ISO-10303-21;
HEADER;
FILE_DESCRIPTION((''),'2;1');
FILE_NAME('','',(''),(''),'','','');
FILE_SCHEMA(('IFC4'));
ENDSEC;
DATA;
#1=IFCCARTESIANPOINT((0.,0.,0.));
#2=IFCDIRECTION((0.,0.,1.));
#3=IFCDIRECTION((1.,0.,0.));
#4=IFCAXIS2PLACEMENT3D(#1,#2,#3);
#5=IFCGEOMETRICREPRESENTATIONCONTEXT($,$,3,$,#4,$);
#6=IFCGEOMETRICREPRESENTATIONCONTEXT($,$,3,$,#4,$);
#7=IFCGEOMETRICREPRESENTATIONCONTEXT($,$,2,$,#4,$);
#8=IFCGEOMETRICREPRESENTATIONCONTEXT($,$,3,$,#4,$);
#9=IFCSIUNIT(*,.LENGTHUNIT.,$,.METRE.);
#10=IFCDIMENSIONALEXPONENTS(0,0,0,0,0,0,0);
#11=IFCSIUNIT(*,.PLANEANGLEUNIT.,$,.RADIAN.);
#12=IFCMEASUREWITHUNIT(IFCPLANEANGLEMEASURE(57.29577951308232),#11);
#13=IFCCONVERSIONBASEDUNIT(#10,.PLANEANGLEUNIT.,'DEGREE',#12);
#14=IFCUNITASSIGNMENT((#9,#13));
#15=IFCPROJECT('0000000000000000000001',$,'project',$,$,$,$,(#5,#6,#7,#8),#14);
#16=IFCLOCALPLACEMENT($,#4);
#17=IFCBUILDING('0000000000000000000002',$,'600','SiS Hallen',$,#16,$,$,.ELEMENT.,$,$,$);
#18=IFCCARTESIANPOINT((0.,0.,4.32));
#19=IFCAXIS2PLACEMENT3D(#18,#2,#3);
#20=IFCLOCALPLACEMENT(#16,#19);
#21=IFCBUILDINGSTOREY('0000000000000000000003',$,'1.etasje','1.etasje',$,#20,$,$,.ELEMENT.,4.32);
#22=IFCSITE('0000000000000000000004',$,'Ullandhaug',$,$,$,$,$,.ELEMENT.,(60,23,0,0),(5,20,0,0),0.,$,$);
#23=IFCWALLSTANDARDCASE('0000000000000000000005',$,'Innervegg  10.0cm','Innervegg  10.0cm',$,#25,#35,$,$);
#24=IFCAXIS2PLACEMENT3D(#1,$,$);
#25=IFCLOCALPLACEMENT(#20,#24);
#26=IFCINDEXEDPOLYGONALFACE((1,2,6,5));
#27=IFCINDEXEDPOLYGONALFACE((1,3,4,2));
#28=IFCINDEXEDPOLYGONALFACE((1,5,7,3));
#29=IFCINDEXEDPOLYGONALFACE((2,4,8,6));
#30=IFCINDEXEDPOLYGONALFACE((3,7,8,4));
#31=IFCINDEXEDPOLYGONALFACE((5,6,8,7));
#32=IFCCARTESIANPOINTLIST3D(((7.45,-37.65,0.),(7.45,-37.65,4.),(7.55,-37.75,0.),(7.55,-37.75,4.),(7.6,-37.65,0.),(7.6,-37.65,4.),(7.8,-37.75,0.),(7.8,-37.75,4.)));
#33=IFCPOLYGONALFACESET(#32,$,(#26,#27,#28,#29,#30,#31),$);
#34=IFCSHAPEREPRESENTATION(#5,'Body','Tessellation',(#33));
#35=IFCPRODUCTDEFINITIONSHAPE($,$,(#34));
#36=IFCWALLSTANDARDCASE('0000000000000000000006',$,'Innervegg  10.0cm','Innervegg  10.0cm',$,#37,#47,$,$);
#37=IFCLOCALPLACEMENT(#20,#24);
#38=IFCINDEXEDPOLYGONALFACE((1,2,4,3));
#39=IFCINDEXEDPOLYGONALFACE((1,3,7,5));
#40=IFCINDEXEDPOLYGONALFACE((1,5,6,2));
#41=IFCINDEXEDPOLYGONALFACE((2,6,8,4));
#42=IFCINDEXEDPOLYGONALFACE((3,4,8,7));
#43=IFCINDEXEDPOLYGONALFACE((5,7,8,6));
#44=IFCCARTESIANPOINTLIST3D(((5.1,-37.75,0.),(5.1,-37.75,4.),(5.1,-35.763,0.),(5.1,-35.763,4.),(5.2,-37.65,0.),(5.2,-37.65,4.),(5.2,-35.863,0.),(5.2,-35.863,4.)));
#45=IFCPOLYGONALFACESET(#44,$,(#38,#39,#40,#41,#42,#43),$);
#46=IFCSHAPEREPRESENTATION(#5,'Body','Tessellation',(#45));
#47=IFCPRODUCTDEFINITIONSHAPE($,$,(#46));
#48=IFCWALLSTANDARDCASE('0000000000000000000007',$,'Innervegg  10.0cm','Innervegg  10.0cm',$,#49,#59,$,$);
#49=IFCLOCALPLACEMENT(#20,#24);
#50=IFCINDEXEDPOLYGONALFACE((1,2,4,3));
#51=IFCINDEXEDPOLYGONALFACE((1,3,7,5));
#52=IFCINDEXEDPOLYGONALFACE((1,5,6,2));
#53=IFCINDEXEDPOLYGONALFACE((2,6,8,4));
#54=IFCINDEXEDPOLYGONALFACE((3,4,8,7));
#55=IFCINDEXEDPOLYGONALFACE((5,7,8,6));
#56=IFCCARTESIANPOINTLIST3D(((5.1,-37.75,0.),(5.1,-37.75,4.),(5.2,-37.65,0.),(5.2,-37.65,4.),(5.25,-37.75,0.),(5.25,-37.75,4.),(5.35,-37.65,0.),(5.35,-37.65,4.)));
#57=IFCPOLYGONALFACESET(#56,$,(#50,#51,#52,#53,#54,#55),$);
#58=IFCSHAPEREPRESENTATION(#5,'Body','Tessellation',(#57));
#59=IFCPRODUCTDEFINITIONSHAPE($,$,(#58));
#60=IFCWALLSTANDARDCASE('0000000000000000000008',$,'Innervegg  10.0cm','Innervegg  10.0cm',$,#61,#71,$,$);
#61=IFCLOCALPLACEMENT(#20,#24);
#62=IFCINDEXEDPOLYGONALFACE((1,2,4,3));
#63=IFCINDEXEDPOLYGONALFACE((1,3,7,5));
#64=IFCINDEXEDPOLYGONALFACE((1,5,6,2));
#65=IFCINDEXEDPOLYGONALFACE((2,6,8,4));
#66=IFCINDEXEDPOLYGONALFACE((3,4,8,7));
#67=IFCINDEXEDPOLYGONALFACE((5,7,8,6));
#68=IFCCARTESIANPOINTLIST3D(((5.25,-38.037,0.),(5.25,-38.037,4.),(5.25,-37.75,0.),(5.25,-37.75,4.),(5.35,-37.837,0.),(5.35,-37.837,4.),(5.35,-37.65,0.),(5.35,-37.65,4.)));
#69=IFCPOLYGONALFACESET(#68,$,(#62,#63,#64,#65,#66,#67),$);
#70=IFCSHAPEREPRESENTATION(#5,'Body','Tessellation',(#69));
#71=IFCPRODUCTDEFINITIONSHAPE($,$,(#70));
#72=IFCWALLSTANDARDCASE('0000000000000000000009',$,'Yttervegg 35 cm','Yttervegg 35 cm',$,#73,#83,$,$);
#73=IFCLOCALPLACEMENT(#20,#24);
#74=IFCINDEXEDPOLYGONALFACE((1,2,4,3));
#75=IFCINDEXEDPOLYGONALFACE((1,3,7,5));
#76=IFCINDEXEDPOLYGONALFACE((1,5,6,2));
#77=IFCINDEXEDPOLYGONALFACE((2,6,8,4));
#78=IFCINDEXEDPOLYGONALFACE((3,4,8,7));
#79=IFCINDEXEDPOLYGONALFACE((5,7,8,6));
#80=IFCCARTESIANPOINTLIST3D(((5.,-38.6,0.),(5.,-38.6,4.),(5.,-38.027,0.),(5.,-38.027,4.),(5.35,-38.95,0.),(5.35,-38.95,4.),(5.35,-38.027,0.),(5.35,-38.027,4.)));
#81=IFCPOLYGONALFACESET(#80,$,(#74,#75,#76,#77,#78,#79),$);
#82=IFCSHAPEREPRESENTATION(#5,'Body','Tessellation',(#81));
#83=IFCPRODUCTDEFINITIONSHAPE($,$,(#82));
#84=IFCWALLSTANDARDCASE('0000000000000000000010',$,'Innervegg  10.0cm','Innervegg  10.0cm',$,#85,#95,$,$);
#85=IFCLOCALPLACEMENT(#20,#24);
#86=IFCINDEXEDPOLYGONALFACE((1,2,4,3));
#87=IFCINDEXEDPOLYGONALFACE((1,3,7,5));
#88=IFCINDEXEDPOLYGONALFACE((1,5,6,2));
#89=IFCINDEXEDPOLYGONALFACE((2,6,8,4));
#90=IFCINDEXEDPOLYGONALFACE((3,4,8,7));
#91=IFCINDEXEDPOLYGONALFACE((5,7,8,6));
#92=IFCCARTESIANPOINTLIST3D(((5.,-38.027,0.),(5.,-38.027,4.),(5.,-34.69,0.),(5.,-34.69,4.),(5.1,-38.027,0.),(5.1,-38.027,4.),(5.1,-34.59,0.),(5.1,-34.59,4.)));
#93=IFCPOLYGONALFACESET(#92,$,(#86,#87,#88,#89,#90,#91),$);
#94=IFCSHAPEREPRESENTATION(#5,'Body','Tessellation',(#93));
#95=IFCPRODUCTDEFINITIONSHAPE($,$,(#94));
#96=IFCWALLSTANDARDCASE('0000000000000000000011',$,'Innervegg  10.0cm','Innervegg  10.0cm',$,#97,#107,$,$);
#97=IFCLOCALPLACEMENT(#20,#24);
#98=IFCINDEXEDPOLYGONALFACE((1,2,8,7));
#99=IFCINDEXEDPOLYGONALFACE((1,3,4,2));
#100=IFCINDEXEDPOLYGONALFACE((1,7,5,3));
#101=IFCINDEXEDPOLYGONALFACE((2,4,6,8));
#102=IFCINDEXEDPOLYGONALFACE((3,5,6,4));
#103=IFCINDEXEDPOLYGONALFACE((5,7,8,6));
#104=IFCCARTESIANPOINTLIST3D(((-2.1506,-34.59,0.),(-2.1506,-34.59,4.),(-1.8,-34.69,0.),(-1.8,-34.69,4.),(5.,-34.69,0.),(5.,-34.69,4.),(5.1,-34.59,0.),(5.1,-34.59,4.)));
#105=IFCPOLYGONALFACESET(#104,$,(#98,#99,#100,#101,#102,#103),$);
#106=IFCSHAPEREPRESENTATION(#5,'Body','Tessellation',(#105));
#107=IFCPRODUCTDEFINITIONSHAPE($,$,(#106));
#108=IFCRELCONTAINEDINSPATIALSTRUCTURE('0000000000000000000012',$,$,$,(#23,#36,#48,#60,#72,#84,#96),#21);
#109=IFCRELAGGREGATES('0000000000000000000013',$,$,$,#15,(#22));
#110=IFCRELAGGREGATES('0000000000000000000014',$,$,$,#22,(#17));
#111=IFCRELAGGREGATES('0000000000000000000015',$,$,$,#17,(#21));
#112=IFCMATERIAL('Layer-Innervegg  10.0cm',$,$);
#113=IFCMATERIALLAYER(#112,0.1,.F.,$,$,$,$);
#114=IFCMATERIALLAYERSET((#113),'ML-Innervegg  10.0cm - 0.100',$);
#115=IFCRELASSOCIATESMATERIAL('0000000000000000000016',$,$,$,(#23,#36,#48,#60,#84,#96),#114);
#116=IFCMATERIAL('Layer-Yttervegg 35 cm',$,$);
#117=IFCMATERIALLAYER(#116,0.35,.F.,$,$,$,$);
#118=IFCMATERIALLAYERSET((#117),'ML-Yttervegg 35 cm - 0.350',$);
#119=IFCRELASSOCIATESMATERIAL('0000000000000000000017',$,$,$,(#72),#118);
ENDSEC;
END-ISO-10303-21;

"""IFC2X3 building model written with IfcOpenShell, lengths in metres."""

from ifc_helpers import new_model, entity, si_unit, converted_unit, frame, origin_with_axes, place, context, project, spatial, polyline, outline, extrude, material, layer, layer_set, layer_usage, element, save


model = new_model("IFC2X3")

# Units and contexts
context_of_model_1 = context(None, 3, world=origin_with_axes())
context_of_model_2 = context(None, 3, world=origin_with_axes())
context_of_model_3 = context(None, 2, world=origin_with_axes())
context_of_model_4 = context(None, 3, world=origin_with_axes())
ifc_project = project(units=[si_unit("LENGTHUNIT", "METRE"), converted_unit("PLANEANGLEUNIT", "DEGREE", entity("IfcPlaneAngleMeasure", 57.29577951308232), si_unit("PLANEANGLEUNIT", "RADIAN"), dimensions=[0, 0, 0, 0, 0, 0, 0])], contexts=[context_of_model_1, context_of_model_2, context_of_model_3, context_of_model_4])

# Site, building, storey
site = spatial("IfcSite", under=ifc_project, Name="Ullandhaug", CompositionType="ELEMENT", RefLatitude=(60, 23, 0, 0), RefLongitude=(5, 20, 0, 0), RefElevation=0.0)
building_placement = place(None, origin_with_axes())
building = spatial("IfcBuilding", under=site, at=building_placement, Name="600", Description="SiS Hallen", CompositionType="ELEMENT")
storey_placement = place(building_placement, frame((0.0, 0.0, 4.32), z_axis=(0.0, 0.0, 1.0), x_axis=(1.0, 0.0, 0.0)))
storey = spatial("IfcBuildingStorey", under=building, at=storey_placement, Name="1.etasje", Description="1.etasje", CompositionType="ELEMENT", Elevation=4.32)

# Shared definitions
ifc_material_1 = material(Name="Layer-Innervegg  10.0cm")
ifc_layer_1 = layer(ifc_material_1, 0.1, ventilated=False)
ifc_layer_set_1 = layer_set([ifc_layer_1], Name="ML-Innervegg  10.0cm - 0.100")
ifc_layer_usage_1 = layer_usage(ifc_layer_set_1, "AXIS2", "POSITIVE", 0.0)

# Shared definitions
ifc_material_2 = material(Name="Layer-Yttervegg 35 cm")
ifc_layer_2 = layer(ifc_material_2, 0.35, ventilated=False)
ifc_layer_set_2 = layer_set([ifc_layer_2], Name="ML-Yttervegg 35 cm - 0.350")
ifc_layer_usage_2 = layer_usage(ifc_layer_set_2, "AXIS2", "POSITIVE", 0.0)

# Walls
wall_1_placement = place(storey_placement, frame((7.55, -37.75, 0.0), z_axis=(0.0, 0.0, 1.0), x_axis=(1.0, 0.0, 0.0)))
element("IfcWallStandardCase", 1, at=wall_1_placement, inside=storey, material=ifc_layer_usage_1, Name="Innervegg  10.0cm", Description="Innervegg  10.0cm", context=context_of_model_1, shape_type="SweptSolid", body=[
    extrude(outline(polyline([(0.0, 0.0), (0.25, 0.0), (0.05, 0.1), (-0.1, 0.1), (0.0, 0.0)])), origin_with_axes(), (0.0, 0.0, 1.0), 4.0),
])
wall_2_placement = place(storey_placement, frame((5.1, -35.763, 0.0), z_axis=(0.0, 0.0, 1.0), x_axis=(0.0, -1.0, 0.0)))
element("IfcWallStandardCase", 2, at=wall_2_placement, inside=storey, material=ifc_layer_usage_1, Name="Innervegg  10.0cm", Description="Innervegg  10.0cm", context=context_of_model_1, shape_type="SweptSolid", body=[
    extrude(outline(polyline([(0.0, 0.0), (1.987, 0.0), (1.887, 0.1), (0.1, 0.1), (0.0, 0.0)])), frame((0.0, 0.0, 0.0), z_axis=(0.0, 0.0, 1.0), x_axis=(1.0, 0.0, 0.0)), (0.0, 0.0, 1.0), 4.0),
])
wall_3_placement = place(storey_placement, frame((5.1, -37.75, 0.0), z_axis=(0.0, 0.0, 1.0), x_axis=(1.0, 0.0, 0.0)))
element("IfcWallStandardCase", 3, at=wall_3_placement, inside=storey, material=ifc_layer_usage_1, Name="Innervegg  10.0cm", Description="Innervegg  10.0cm", context=context_of_model_1, shape_type="SweptSolid", body=[
    extrude(outline(polyline([(0.0, 0.0), (0.15, 0.0), (0.25, 0.1), (0.1, 0.1), (0.0, 0.0)])), origin_with_axes(), (0.0, 0.0, 1.0), 4.0),
])
wall_4_placement = place(storey_placement, frame((5.25, -37.75, 0.0), z_axis=(0.0, 0.0, 1.0), x_axis=(0.0, -1.0, 0.0)))
element("IfcWallStandardCase", 4, at=wall_4_placement, inside=storey, material=ifc_layer_usage_1, Name="Innervegg  10.0cm", Description="Innervegg  10.0cm", context=context_of_model_1, shape_type="SweptSolid", body=[
    extrude(outline(polyline([(0.0, 0.0), (0.287, 0.0), (0.087, 0.1), (-0.1, 0.1), (0.0, 0.0)])), frame((0.0, 0.0, 0.0), z_axis=(0.0, 0.0, 1.0), x_axis=(1.0, 0.0, 0.0)), (0.0, 0.0, 1.0), 4.0),
])
wall_5_placement = place(storey_placement, frame((5.35, -38.95, 0.0), z_axis=(0.0, 0.0, 1.0), x_axis=(0.0, 1.0, 0.0)))
element("IfcWallStandardCase", 5, at=wall_5_placement, inside=storey, material=ifc_layer_usage_2, Name="Yttervegg 35 cm", Description="Yttervegg 35 cm", context=context_of_model_1, shape_type="SweptSolid", body=[
    extrude(outline(polyline([(0.0, 0.0), (0.923, 0.0), (0.923, 0.35), (0.35, 0.35), (0.0, 0.0)])), frame((0.0, 0.0, 0.0), z_axis=(0.0, 0.0, 1.0), x_axis=(1.0, 0.0, 0.0)), (0.0, 0.0, 1.0), 4.0),
])
wall_6_placement = place(storey_placement, frame((5.1, -38.027, 0.0), z_axis=(0.0, 0.0, 1.0), x_axis=(0.0, 1.0, 0.0)))
element("IfcWallStandardCase", 6, at=wall_6_placement, inside=storey, material=ifc_layer_usage_1, Name="Innervegg  10.0cm", Description="Innervegg  10.0cm", context=context_of_model_1, shape_type="SweptSolid", body=[
    extrude(outline(polyline([(0.0, 0.0), (3.437, 0.0), (3.337, 0.1), (0.0, 0.1), (0.0, 0.0)])), frame((0.0, 0.0, 0.0), z_axis=(0.0, 0.0, 1.0), x_axis=(1.0, 0.0, 0.0)), (0.0, 0.0, 1.0), 4.0),
])
wall_7_placement = place(storey_placement, frame((5.1, -34.59, 0.0), z_axis=(0.0, 0.0, 1.0), x_axis=(-1.0, 0.0, 0.0)))
element("IfcWallStandardCase", 7, at=wall_7_placement, inside=storey, material=ifc_layer_usage_1, Name="Innervegg  10.0cm", Description="Innervegg  10.0cm", context=context_of_model_1, shape_type="SweptSolid", body=[
    extrude(outline(polyline([(0.0, 0.0), (7.2506, 0.0), (6.9, 0.1), (0.1, 0.1), (0.0, 0.0)])), frame((0.0, 0.0, 0.0), z_axis=(0.0, 0.0, 1.0), x_axis=(1.0, 0.0, 0.0)), (0.0, 0.0, 1.0), 4.0),
])

save(model, "model.ifc")
